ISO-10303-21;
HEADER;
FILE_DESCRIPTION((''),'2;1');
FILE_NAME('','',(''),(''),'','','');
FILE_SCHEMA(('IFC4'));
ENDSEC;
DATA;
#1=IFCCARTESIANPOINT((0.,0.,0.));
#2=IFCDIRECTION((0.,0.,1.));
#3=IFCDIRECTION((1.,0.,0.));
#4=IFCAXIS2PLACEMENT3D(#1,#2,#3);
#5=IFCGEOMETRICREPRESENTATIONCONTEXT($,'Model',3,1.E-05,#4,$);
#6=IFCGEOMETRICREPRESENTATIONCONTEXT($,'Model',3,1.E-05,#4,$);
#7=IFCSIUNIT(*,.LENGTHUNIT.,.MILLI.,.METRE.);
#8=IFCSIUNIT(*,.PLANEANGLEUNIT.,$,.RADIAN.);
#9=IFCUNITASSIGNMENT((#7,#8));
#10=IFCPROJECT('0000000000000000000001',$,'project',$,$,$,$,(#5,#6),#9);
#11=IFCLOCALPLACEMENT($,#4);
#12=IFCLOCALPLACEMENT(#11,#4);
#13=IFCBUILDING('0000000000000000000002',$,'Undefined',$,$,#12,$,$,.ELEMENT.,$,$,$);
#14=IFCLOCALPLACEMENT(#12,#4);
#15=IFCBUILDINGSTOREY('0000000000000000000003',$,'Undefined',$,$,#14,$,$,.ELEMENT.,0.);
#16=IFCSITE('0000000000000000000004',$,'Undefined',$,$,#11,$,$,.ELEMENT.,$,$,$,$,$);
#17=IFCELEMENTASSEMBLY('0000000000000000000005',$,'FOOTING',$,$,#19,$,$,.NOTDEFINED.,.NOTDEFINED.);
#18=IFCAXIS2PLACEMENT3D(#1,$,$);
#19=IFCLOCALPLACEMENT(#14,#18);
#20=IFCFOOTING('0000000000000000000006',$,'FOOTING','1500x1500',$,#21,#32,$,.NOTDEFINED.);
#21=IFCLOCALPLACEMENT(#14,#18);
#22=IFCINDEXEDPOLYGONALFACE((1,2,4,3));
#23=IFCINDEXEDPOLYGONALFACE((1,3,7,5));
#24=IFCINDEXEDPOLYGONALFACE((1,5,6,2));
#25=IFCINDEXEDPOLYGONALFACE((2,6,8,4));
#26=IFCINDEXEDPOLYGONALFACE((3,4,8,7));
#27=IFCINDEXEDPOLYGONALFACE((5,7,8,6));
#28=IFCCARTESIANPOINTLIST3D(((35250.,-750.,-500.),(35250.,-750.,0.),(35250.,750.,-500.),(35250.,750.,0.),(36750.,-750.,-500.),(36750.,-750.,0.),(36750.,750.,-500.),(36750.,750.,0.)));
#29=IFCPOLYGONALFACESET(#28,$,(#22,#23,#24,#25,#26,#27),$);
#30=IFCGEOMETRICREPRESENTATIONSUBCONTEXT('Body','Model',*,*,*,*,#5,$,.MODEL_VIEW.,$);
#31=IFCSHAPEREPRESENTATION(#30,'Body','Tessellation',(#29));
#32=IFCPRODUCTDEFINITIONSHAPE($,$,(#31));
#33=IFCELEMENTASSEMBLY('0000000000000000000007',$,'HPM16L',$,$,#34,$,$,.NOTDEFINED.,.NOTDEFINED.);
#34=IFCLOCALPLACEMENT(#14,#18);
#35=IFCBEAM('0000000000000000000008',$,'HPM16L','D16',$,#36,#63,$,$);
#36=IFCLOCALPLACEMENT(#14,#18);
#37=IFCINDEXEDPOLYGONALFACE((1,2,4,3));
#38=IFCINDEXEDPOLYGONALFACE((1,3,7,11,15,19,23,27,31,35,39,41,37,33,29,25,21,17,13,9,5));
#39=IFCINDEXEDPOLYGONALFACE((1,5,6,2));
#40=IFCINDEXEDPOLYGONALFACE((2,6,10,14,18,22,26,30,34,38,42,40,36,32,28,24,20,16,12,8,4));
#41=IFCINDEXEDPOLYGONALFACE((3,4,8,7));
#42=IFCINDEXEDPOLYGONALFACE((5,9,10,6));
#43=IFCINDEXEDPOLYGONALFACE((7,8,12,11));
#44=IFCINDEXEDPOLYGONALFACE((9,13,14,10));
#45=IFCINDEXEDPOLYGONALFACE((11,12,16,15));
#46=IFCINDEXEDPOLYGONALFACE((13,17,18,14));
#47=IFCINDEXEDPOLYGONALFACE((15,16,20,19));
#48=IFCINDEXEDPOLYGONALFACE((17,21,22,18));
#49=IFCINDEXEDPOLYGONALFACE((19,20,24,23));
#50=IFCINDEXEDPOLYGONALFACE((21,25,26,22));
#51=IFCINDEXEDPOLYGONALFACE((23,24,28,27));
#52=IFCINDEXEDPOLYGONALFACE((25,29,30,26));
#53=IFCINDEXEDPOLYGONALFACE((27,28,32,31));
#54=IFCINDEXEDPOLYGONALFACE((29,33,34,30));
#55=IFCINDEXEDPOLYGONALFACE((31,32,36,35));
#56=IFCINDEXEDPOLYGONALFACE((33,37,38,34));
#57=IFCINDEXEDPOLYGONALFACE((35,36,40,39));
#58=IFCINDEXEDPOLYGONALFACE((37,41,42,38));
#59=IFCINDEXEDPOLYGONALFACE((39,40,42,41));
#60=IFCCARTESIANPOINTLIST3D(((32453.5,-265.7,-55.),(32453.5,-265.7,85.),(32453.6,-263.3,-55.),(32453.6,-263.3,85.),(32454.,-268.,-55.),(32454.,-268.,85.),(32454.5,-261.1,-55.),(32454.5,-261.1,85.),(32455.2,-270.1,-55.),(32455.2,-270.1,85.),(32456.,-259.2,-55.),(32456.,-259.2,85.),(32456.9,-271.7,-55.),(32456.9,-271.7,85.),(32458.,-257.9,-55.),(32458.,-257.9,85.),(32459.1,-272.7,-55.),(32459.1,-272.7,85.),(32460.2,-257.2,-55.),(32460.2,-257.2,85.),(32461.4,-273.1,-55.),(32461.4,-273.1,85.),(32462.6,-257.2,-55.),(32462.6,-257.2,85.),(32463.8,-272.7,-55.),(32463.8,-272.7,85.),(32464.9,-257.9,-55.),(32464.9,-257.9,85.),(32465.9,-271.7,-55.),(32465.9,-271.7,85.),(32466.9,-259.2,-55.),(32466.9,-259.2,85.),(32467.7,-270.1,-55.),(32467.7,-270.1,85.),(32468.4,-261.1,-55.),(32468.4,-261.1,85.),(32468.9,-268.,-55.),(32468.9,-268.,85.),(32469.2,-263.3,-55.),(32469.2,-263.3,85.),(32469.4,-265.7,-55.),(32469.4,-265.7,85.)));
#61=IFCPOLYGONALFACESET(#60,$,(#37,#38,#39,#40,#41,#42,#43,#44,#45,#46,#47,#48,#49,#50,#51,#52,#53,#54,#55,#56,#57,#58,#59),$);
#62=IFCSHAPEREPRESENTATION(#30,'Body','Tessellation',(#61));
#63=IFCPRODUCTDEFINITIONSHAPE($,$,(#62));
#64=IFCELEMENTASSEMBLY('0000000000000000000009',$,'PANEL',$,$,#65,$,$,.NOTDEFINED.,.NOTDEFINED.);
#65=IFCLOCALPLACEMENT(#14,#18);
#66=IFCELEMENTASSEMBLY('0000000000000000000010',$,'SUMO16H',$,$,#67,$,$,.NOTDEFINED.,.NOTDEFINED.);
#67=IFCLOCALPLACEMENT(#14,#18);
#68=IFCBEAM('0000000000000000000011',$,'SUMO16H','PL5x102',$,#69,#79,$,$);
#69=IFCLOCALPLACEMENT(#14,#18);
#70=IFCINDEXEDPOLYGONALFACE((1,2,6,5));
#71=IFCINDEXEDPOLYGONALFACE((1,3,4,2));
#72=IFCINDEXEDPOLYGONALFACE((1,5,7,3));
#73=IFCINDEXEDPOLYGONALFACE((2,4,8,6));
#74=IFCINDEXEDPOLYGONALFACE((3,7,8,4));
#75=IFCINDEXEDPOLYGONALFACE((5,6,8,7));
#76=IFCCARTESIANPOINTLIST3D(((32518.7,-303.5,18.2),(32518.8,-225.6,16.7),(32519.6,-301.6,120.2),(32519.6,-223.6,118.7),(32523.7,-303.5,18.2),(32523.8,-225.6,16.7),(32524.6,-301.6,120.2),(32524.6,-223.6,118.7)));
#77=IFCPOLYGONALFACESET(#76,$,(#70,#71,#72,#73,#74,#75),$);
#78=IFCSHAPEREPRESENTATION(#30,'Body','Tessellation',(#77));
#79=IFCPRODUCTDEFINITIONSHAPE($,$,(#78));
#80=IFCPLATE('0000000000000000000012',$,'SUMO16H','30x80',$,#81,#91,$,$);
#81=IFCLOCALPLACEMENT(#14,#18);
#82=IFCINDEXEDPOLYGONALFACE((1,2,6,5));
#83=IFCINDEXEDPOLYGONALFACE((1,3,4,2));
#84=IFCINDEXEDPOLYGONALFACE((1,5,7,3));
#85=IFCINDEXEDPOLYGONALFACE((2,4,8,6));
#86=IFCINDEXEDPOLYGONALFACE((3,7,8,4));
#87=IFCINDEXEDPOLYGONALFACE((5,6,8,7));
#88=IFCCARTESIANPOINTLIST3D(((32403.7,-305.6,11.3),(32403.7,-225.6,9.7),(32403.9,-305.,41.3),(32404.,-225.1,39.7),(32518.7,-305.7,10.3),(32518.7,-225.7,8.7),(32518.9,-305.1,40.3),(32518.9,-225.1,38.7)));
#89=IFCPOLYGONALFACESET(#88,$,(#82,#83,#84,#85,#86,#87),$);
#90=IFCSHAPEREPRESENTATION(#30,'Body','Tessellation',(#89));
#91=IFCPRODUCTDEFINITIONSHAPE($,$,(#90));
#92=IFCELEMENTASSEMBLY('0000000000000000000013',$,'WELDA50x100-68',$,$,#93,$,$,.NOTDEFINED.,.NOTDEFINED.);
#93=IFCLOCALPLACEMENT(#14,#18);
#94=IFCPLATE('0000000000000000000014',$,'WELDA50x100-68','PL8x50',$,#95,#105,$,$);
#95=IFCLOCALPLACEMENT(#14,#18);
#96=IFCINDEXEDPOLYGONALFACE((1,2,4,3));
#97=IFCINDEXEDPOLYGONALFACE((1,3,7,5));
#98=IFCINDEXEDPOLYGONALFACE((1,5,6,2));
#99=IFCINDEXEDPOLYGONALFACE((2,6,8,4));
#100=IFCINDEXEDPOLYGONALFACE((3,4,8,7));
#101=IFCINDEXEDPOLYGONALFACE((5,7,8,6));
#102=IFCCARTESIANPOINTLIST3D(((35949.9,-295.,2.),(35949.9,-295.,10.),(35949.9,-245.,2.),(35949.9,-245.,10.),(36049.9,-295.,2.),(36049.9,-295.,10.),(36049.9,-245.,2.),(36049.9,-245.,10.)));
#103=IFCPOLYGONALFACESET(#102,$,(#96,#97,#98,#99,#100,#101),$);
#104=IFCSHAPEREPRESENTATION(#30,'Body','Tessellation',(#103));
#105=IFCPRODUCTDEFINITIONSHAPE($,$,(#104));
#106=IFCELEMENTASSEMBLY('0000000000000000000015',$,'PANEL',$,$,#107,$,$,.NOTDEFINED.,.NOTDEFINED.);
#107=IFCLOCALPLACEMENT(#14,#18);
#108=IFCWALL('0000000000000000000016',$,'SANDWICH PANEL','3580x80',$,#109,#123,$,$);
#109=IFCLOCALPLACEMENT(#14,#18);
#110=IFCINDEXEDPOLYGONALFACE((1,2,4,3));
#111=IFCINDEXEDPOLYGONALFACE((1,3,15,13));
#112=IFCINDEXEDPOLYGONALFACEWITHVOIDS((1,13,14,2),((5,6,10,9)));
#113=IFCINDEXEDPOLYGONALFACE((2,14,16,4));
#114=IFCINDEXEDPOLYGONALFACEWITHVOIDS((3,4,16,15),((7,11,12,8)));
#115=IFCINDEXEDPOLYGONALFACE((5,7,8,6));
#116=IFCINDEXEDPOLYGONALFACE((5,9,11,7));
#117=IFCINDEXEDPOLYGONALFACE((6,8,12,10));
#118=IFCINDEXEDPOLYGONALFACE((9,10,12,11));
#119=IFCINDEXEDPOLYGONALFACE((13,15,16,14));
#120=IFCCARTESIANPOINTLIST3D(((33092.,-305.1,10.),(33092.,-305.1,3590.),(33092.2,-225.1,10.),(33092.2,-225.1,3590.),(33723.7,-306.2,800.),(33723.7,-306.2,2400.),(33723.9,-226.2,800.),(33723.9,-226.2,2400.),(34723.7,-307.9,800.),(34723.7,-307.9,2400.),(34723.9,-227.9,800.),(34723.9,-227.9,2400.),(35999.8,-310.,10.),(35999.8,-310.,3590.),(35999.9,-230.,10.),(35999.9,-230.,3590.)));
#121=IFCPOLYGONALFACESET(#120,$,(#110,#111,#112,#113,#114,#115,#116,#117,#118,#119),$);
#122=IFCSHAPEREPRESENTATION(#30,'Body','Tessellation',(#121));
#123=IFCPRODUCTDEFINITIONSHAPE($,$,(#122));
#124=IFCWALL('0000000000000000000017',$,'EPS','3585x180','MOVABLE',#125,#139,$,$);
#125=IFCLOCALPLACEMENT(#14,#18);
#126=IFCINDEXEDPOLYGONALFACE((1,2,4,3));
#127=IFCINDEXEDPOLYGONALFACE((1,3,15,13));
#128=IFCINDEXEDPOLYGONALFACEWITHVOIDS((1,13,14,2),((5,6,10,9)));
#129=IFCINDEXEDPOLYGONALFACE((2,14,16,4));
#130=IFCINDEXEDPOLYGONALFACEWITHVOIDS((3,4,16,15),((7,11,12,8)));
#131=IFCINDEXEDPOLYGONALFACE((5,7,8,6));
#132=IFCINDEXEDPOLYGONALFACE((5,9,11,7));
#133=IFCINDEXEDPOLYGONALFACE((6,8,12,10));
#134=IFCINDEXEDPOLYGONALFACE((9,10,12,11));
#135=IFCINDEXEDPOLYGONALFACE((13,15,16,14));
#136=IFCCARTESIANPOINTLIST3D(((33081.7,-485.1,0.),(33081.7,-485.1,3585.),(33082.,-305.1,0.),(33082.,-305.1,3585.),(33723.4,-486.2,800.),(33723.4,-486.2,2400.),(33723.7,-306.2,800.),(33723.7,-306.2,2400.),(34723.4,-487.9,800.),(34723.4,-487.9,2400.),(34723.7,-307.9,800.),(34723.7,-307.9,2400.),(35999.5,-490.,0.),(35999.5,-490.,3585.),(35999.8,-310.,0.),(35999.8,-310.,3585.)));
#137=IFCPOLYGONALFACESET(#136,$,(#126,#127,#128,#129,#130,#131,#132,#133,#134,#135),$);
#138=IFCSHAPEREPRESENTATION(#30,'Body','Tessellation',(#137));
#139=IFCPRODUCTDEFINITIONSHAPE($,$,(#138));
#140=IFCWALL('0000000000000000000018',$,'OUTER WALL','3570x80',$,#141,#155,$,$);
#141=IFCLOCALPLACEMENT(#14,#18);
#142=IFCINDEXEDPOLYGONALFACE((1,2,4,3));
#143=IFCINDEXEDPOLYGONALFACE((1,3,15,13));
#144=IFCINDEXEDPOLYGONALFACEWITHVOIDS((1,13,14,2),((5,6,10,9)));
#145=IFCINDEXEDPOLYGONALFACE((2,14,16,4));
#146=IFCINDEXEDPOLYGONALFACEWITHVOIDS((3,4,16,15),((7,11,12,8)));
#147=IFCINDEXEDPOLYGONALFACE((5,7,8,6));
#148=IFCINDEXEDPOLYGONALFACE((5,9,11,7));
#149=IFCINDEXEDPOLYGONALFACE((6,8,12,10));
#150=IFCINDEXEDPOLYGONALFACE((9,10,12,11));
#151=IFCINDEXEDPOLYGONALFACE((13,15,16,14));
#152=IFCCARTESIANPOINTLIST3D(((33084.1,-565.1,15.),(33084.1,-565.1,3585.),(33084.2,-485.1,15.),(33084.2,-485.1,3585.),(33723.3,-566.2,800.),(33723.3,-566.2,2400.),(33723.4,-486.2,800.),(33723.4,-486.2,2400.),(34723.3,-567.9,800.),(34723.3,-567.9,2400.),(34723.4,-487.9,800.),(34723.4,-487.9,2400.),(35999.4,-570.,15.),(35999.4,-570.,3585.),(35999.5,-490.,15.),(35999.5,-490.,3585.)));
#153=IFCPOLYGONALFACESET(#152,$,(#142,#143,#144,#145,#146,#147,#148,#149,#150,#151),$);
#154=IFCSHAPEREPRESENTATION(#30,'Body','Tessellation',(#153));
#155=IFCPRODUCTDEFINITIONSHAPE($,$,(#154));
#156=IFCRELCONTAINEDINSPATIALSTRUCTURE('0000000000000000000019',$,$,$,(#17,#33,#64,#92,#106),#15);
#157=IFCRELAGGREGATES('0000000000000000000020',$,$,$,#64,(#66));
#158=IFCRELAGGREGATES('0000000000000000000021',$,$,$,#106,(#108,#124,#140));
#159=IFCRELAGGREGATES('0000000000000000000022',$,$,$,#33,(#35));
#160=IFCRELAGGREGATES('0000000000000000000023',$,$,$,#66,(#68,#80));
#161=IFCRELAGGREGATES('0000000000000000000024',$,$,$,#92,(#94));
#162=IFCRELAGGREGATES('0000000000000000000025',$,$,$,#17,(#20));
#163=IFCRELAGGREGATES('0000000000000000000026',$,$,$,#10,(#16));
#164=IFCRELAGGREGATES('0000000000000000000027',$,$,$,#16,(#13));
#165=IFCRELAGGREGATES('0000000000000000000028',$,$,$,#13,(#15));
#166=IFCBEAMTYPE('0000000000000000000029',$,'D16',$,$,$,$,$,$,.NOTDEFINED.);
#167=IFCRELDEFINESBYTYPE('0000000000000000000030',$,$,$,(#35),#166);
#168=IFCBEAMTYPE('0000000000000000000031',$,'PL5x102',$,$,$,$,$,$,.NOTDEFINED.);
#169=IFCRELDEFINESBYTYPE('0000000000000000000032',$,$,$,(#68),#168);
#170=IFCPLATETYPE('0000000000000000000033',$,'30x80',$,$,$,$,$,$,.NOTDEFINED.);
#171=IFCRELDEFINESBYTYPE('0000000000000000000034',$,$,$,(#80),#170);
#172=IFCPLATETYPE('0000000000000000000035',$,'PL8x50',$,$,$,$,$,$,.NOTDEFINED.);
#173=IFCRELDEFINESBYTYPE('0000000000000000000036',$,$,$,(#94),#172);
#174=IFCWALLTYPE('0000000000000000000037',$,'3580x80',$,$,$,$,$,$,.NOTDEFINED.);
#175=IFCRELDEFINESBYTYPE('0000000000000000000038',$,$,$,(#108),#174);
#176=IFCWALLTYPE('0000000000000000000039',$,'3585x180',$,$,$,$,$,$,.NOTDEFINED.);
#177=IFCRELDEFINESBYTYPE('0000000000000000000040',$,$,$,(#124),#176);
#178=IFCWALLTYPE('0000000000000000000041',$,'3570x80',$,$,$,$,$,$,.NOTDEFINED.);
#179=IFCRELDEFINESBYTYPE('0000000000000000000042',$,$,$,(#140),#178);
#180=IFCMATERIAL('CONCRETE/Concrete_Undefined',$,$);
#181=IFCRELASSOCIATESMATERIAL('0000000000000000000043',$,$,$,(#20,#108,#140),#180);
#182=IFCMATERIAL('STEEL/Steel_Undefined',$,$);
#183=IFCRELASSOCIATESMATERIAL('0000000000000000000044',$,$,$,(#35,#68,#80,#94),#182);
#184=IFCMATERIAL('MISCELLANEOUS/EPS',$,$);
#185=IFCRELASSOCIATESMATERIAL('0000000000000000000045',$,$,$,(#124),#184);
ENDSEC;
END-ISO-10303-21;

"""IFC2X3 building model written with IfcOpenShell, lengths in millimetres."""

from ifc_helpers import new_model, si_unit, frame, frame_2d, origin_with_axes, origin_2d_with_axis, place, context, subcontext, project, spatial, polyline, rectangle, circle, outline, extrude, material, type_object, element, aggregate, save


model = new_model("IFC2X3")

# Units and contexts
model_context_1 = context("Model", 3, precision=1e-05, world=origin_with_axes())
model_context_2 = context("Model", 3, precision=1e-05, world=origin_with_axes())
body_context = subcontext(model_context_1, "Body", "Model", "MODEL_VIEW")
ifc_project = project(units=[si_unit("LENGTHUNIT", "METRE", prefix="MILLI"), si_unit("PLANEANGLEUNIT", "RADIAN")], contexts=[model_context_1, model_context_2])

# Site, building, storey
site_placement = place(None, origin_with_axes())
site = spatial("IfcSite", under=ifc_project, at=site_placement, Name="Undefined", CompositionType="ELEMENT")
building_placement = place(site_placement, origin_with_axes())
building = spatial("IfcBuilding", under=site, at=building_placement, Name="Undefined", CompositionType="ELEMENT")
storey_placement = place(building_placement, origin_with_axes())
storey = spatial("IfcBuildingStorey", under=building, at=storey_placement, Name="Undefined", CompositionType="ELEMENT", Elevation=0.0)

# Element assembly, footing
assembly_1_placement = place(storey_placement, origin_with_axes())
assembly_1 = element("IfcElementAssembly", 1, at=assembly_1_placement, inside=storey, Name="FOOTING", AssemblyPlace="NOTDEFINED", PredefinedType="NOTDEFINED")
ifc_material_1 = material(Name="CONCRETE/Concrete_Undefined")
footing_placement = place(assembly_1_placement, frame((36000.0, 0.0, -500.0), z_axis=(0.0, 1.0, 0.0), x_axis=(0.0, 0.0, 1.0)))
footing = element("IfcFooting", 2, at=footing_placement, material=ifc_material_1, Name="FOOTING", Description="1500x1500", PredefinedType="NOTDEFINED", context=body_context, shape_type="SweptSolid", body=[
    extrude(rectangle(XDim=1500.0, YDim=1500.0, at=origin_2d_with_axis()), frame((500.0, 0.0, 0.0), z_axis=(-1.0, 0.0, 0.0), x_axis=(0.0, -1.0, 0.0)), (0.0, 0.0, 1.0), 500.0),
])

# Element assembly, beam
assembly_2_placement = place(storey_placement, origin_with_axes())
assembly_2 = element("IfcElementAssembly", 3, at=assembly_2_placement, inside=storey, Name="HPM16L", AssemblyPlace="NOTDEFINED", PredefinedType="NOTDEFINED")
ifc_material_2 = material(Name="STEEL/Steel_Undefined")
beam_type_1 = type_object("IfcBeamType", Name="D16", PredefinedType="NOTDEFINED")
beam_1_placement = place(assembly_2_placement, frame((32461.4, -265.1, 85.0), z_axis=(1.0, 0.0, 0.0), x_axis=(0.0, 0.0, -1.0)))
beam_1 = element("IfcBeam", 4, at=beam_1_placement, type_object=beam_type_1, material=ifc_material_2, Name="HPM16L", Description="D16", context=body_context, shape_type="SweptSolid", body=[
    extrude(circle(Radius=8.0, at=origin_2d_with_axis()), frame((140.0, 0.0, 0.0), z_axis=(-1.0, 0.0, 0.0), x_axis=(0.0, -1.0, 0.0)), (0.0, 0.0, 1.0), 140.0),
])

# Element assemblies, beam, plate
assembly_3_placement = place(storey_placement, origin_with_axes())
assembly_3 = element("IfcElementAssembly", 5, at=assembly_3_placement, inside=storey, Name="PANEL", AssemblyPlace="NOTDEFINED", PredefinedType="NOTDEFINED")
assembly_4_placement = place(assembly_3_placement, origin_with_axes())
assembly_4 = element("IfcElementAssembly", 6, at=assembly_4_placement, Name="SUMO16H", AssemblyPlace="NOTDEFINED", PredefinedType="NOTDEFINED")
aggregate(assembly_3, [assembly_4])
beam_type_2 = type_object("IfcBeamType", Name="PL5x102", PredefinedType="NOTDEFINED")
beam_2_placement = place(assembly_4_placement, frame((32521.7, -224.6, 67.7), z_axis=(0.008618, 0.019092, 0.999781), x_axis=(-0.000494, -0.999818, 0.019097)))
beam_2 = element("IfcBeam", 7, at=beam_2_placement, type_object=beam_type_2, material=ifc_material_2, Name="SUMO16H", Description="PL5x102", context=body_context, shape_type="SweptSolid", body=[
    extrude(rectangle(XDim=5.0, YDim=102.0, at=origin_2d_with_axis()), frame((78.0, 0.0, 0.0), z_axis=(-1.0, 0.0, 0.0), x_axis=(0.0, -1.0, 0.0)), (0.0, 0.0, 1.0), 78.0),
])
plate_type_1 = type_object("IfcPlateType", Name="30x80", PredefinedType="NOTDEFINED")
plate_1_placement = place(assembly_4_placement, frame((32518.8, -225.4, 23.7), z_axis=(0.008618, 0.019092, 0.999781), x_axis=(-0.999963, 0.000658, 0.008607)))
plate_1 = element("IfcPlate", 8, at=plate_1_placement, type_object=plate_type_1, material=ifc_material_2, Name="SUMO16H", Description="30x80", context=body_context, shape_type="SweptSolid", body=[
    extrude(outline(polyline([(0.0, 0.0), (115.0, 0.0), (115.0, 80.0), (0.0, 80.0), (0.0, 0.0)])), frame((0.0, 0.0, -15.0), z_axis=(0.0, 0.0, 1.0), x_axis=(1.0, 0.0, 0.0)), (0.0, 0.0, 1.0), 30.0),
])

# Element assembly, plate
assembly_5_placement = place(storey_placement, origin_with_axes())
assembly_5 = element("IfcElementAssembly", 9, at=assembly_5_placement, inside=storey, Name="WELDA50x100-68", AssemblyPlace="NOTDEFINED", PredefinedType="NOTDEFINED")
plate_type_2 = type_object("IfcPlateType", Name="PL8x50", PredefinedType="NOTDEFINED")
plate_2_placement = place(assembly_5_placement, frame((35949.9, -295.0, 6.0), z_axis=(0.0, 0.0, 1.0), x_axis=(1.0, 0.0, 0.0)))
plate_2 = element("IfcPlate", 10, at=plate_2_placement, type_object=plate_type_2, material=ifc_material_2, Name="WELDA50x100-68", Description="PL8x50", context=body_context, shape_type="SweptSolid", body=[
    extrude(outline(polyline([(0.0, 0.0), (100.0, 0.0), (100.0, 50.0), (0.0, 50.0), (0.0, 0.0)])), frame((0.0, 0.0, -4.0), z_axis=(0.0, 0.0, 1.0), x_axis=(1.0, 0.0, 0.0)), (0.0, 0.0, 1.0), 8.0),
])

# Element assembly, walls, openings
assembly_6_placement = place(storey_placement, origin_with_axes())
assembly_6 = element("IfcElementAssembly", 11, at=assembly_6_placement, inside=storey, Name="PANEL", AssemblyPlace="NOTDEFINED", PredefinedType="NOTDEFINED")
wall_type_1 = type_object("IfcWallType", Name="3580x80", PredefinedType="NOTDEFINED")
wall_1_placement = place(assembly_6_placement, frame((33092.1, -265.1, 10.0), z_axis=(0.0, 0.0, 1.0), x_axis=(0.999999, -0.001684, 0.0)))
wall_1 = element("IfcWall", 12, at=wall_1_placement, type_object=wall_type_1, material=ifc_material_1, Name="SANDWICH PANEL", Description="3580x80", context=body_context, shape_type="SweptSolid", body=[
    extrude(rectangle(XDim=2907.8, YDim=80.0, at=frame_2d((0.0, 1453.9), x_axis=(0.0, -1.0))), frame((0.0, 0.0, 0.0), z_axis=(0.0, 0.0, 1.0), x_axis=(0.0, -1.0, 0.0)), (0.0, 0.0, 1.0), 3580.0),
])
opening_1_placement = place(assembly_6_placement, frame((33092.1, -265.1, 10.0), z_axis=(0.0, 0.0, 1.0), x_axis=(0.999999, -0.001684, 0.0)))
element("IfcOpeningElement", 13, at=opening_1_placement, cuts=wall_1, ObjectType="Recess", context=body_context, shape_type="SweptSolid", body=[
    extrude(outline(polyline([(0.0, 0.0), (1000.0, 0.0), (1000.0, 1600.0), (0.0, 1600.0), (0.0, 0.0)])), frame((631.7, 90.0, 790.0), z_axis=(0.0, -1.0, 0.0), x_axis=(1.0, 0.0, 0.0)), (0.0, 0.0, 1.0), 180.0),
])
ifc_material_3 = material(Name="MISCELLANEOUS/EPS")
wall_type_2 = type_object("IfcWallType", Name="3585x180", PredefinedType="NOTDEFINED")
wall_2_placement = place(assembly_6_placement, frame((33081.9, -395.1, 0.0), z_axis=(0.0, 0.0, 1.0), x_axis=(0.999999, -0.001684, 0.0)))
wall_2 = element("IfcWall", 14, at=wall_2_placement, type_object=wall_type_2, material=ifc_material_3, Name="EPS", Description="3585x180", ObjectType="MOVABLE", context=body_context, shape_type="SweptSolid", body=[
    extrude(rectangle(XDim=2917.8, YDim=180.0, at=frame_2d((0.0, 1458.9), x_axis=(0.0, -1.0))), frame((0.0, 0.0, 0.0), z_axis=(0.0, 0.0, 1.0), x_axis=(0.0, -1.0, 0.0)), (0.0, 0.0, 1.0), 3585.0),
])
opening_2_placement = place(assembly_6_placement, frame((33081.9, -395.1, 0.0), z_axis=(0.0, 0.0, 1.0), x_axis=(0.999999, -0.001684, 0.0)))
element("IfcOpeningElement", 15, at=opening_2_placement, cuts=wall_2, ObjectType="Recess", context=body_context, shape_type="SweptSolid", body=[
    extrude(outline(polyline([(0.0, 0.0), (1000.0, 0.0), (1000.0, 1600.0), (0.0, 1600.0), (0.0, 0.0)])), frame((641.7, 140.0, 800.0), z_axis=(0.0, -1.0, 0.0), x_axis=(1.0, 0.0, 0.0)), (0.0, 0.0, 1.0), 280.0),
])
wall_type_3 = type_object("IfcWallType", Name="3570x80", PredefinedType="NOTDEFINED")
wall_3_placement = place(assembly_6_placement, frame((33084.1, -525.1, 15.0), z_axis=(0.0, 0.0, 1.0), x_axis=(0.999999, -0.001684, 0.0)))
wall_3 = element("IfcWall", 16, at=wall_3_placement, type_object=wall_type_3, material=ifc_material_1, Name="OUTER WALL", Description="3570x80", context=body_context, shape_type="SweptSolid", body=[
    extrude(rectangle(XDim=2915.3, YDim=80.0, at=frame_2d((0.0, 1457.7), x_axis=(0.0, -1.0))), frame((0.0, 0.0, 0.0), z_axis=(0.0, 0.0, 1.0), x_axis=(0.0, -1.0, 0.0)), (0.0, 0.0, 1.0), 3570.0),
])
opening_3_placement = place(assembly_6_placement, frame((33084.1, -525.1, 15.0), z_axis=(0.0, 0.0, 1.0), x_axis=(0.999999, -0.001684, 0.0)))
element("IfcOpeningElement", 17, at=opening_3_placement, cuts=wall_3, ObjectType="Recess", context=body_context, shape_type="SweptSolid", body=[
    extrude(outline(polyline([(0.0, 0.0), (1000.0, 0.0), (1000.0, 1600.0), (0.0, 1600.0), (0.0, 0.0)])), frame((639.2, 90.0, 785.0), z_axis=(0.0, -1.0, 0.0), x_axis=(1.0, 0.0, 0.0)), (0.0, 0.0, 1.0), 180.0),
])
aggregate(assembly_6, [wall_1, wall_2, wall_3])

aggregate(assembly_2, [beam_1])
aggregate(assembly_4, [beam_2, plate_1])
aggregate(assembly_5, [plate_2])

aggregate(assembly_1, [footing])

save(model, "model.ifc")
